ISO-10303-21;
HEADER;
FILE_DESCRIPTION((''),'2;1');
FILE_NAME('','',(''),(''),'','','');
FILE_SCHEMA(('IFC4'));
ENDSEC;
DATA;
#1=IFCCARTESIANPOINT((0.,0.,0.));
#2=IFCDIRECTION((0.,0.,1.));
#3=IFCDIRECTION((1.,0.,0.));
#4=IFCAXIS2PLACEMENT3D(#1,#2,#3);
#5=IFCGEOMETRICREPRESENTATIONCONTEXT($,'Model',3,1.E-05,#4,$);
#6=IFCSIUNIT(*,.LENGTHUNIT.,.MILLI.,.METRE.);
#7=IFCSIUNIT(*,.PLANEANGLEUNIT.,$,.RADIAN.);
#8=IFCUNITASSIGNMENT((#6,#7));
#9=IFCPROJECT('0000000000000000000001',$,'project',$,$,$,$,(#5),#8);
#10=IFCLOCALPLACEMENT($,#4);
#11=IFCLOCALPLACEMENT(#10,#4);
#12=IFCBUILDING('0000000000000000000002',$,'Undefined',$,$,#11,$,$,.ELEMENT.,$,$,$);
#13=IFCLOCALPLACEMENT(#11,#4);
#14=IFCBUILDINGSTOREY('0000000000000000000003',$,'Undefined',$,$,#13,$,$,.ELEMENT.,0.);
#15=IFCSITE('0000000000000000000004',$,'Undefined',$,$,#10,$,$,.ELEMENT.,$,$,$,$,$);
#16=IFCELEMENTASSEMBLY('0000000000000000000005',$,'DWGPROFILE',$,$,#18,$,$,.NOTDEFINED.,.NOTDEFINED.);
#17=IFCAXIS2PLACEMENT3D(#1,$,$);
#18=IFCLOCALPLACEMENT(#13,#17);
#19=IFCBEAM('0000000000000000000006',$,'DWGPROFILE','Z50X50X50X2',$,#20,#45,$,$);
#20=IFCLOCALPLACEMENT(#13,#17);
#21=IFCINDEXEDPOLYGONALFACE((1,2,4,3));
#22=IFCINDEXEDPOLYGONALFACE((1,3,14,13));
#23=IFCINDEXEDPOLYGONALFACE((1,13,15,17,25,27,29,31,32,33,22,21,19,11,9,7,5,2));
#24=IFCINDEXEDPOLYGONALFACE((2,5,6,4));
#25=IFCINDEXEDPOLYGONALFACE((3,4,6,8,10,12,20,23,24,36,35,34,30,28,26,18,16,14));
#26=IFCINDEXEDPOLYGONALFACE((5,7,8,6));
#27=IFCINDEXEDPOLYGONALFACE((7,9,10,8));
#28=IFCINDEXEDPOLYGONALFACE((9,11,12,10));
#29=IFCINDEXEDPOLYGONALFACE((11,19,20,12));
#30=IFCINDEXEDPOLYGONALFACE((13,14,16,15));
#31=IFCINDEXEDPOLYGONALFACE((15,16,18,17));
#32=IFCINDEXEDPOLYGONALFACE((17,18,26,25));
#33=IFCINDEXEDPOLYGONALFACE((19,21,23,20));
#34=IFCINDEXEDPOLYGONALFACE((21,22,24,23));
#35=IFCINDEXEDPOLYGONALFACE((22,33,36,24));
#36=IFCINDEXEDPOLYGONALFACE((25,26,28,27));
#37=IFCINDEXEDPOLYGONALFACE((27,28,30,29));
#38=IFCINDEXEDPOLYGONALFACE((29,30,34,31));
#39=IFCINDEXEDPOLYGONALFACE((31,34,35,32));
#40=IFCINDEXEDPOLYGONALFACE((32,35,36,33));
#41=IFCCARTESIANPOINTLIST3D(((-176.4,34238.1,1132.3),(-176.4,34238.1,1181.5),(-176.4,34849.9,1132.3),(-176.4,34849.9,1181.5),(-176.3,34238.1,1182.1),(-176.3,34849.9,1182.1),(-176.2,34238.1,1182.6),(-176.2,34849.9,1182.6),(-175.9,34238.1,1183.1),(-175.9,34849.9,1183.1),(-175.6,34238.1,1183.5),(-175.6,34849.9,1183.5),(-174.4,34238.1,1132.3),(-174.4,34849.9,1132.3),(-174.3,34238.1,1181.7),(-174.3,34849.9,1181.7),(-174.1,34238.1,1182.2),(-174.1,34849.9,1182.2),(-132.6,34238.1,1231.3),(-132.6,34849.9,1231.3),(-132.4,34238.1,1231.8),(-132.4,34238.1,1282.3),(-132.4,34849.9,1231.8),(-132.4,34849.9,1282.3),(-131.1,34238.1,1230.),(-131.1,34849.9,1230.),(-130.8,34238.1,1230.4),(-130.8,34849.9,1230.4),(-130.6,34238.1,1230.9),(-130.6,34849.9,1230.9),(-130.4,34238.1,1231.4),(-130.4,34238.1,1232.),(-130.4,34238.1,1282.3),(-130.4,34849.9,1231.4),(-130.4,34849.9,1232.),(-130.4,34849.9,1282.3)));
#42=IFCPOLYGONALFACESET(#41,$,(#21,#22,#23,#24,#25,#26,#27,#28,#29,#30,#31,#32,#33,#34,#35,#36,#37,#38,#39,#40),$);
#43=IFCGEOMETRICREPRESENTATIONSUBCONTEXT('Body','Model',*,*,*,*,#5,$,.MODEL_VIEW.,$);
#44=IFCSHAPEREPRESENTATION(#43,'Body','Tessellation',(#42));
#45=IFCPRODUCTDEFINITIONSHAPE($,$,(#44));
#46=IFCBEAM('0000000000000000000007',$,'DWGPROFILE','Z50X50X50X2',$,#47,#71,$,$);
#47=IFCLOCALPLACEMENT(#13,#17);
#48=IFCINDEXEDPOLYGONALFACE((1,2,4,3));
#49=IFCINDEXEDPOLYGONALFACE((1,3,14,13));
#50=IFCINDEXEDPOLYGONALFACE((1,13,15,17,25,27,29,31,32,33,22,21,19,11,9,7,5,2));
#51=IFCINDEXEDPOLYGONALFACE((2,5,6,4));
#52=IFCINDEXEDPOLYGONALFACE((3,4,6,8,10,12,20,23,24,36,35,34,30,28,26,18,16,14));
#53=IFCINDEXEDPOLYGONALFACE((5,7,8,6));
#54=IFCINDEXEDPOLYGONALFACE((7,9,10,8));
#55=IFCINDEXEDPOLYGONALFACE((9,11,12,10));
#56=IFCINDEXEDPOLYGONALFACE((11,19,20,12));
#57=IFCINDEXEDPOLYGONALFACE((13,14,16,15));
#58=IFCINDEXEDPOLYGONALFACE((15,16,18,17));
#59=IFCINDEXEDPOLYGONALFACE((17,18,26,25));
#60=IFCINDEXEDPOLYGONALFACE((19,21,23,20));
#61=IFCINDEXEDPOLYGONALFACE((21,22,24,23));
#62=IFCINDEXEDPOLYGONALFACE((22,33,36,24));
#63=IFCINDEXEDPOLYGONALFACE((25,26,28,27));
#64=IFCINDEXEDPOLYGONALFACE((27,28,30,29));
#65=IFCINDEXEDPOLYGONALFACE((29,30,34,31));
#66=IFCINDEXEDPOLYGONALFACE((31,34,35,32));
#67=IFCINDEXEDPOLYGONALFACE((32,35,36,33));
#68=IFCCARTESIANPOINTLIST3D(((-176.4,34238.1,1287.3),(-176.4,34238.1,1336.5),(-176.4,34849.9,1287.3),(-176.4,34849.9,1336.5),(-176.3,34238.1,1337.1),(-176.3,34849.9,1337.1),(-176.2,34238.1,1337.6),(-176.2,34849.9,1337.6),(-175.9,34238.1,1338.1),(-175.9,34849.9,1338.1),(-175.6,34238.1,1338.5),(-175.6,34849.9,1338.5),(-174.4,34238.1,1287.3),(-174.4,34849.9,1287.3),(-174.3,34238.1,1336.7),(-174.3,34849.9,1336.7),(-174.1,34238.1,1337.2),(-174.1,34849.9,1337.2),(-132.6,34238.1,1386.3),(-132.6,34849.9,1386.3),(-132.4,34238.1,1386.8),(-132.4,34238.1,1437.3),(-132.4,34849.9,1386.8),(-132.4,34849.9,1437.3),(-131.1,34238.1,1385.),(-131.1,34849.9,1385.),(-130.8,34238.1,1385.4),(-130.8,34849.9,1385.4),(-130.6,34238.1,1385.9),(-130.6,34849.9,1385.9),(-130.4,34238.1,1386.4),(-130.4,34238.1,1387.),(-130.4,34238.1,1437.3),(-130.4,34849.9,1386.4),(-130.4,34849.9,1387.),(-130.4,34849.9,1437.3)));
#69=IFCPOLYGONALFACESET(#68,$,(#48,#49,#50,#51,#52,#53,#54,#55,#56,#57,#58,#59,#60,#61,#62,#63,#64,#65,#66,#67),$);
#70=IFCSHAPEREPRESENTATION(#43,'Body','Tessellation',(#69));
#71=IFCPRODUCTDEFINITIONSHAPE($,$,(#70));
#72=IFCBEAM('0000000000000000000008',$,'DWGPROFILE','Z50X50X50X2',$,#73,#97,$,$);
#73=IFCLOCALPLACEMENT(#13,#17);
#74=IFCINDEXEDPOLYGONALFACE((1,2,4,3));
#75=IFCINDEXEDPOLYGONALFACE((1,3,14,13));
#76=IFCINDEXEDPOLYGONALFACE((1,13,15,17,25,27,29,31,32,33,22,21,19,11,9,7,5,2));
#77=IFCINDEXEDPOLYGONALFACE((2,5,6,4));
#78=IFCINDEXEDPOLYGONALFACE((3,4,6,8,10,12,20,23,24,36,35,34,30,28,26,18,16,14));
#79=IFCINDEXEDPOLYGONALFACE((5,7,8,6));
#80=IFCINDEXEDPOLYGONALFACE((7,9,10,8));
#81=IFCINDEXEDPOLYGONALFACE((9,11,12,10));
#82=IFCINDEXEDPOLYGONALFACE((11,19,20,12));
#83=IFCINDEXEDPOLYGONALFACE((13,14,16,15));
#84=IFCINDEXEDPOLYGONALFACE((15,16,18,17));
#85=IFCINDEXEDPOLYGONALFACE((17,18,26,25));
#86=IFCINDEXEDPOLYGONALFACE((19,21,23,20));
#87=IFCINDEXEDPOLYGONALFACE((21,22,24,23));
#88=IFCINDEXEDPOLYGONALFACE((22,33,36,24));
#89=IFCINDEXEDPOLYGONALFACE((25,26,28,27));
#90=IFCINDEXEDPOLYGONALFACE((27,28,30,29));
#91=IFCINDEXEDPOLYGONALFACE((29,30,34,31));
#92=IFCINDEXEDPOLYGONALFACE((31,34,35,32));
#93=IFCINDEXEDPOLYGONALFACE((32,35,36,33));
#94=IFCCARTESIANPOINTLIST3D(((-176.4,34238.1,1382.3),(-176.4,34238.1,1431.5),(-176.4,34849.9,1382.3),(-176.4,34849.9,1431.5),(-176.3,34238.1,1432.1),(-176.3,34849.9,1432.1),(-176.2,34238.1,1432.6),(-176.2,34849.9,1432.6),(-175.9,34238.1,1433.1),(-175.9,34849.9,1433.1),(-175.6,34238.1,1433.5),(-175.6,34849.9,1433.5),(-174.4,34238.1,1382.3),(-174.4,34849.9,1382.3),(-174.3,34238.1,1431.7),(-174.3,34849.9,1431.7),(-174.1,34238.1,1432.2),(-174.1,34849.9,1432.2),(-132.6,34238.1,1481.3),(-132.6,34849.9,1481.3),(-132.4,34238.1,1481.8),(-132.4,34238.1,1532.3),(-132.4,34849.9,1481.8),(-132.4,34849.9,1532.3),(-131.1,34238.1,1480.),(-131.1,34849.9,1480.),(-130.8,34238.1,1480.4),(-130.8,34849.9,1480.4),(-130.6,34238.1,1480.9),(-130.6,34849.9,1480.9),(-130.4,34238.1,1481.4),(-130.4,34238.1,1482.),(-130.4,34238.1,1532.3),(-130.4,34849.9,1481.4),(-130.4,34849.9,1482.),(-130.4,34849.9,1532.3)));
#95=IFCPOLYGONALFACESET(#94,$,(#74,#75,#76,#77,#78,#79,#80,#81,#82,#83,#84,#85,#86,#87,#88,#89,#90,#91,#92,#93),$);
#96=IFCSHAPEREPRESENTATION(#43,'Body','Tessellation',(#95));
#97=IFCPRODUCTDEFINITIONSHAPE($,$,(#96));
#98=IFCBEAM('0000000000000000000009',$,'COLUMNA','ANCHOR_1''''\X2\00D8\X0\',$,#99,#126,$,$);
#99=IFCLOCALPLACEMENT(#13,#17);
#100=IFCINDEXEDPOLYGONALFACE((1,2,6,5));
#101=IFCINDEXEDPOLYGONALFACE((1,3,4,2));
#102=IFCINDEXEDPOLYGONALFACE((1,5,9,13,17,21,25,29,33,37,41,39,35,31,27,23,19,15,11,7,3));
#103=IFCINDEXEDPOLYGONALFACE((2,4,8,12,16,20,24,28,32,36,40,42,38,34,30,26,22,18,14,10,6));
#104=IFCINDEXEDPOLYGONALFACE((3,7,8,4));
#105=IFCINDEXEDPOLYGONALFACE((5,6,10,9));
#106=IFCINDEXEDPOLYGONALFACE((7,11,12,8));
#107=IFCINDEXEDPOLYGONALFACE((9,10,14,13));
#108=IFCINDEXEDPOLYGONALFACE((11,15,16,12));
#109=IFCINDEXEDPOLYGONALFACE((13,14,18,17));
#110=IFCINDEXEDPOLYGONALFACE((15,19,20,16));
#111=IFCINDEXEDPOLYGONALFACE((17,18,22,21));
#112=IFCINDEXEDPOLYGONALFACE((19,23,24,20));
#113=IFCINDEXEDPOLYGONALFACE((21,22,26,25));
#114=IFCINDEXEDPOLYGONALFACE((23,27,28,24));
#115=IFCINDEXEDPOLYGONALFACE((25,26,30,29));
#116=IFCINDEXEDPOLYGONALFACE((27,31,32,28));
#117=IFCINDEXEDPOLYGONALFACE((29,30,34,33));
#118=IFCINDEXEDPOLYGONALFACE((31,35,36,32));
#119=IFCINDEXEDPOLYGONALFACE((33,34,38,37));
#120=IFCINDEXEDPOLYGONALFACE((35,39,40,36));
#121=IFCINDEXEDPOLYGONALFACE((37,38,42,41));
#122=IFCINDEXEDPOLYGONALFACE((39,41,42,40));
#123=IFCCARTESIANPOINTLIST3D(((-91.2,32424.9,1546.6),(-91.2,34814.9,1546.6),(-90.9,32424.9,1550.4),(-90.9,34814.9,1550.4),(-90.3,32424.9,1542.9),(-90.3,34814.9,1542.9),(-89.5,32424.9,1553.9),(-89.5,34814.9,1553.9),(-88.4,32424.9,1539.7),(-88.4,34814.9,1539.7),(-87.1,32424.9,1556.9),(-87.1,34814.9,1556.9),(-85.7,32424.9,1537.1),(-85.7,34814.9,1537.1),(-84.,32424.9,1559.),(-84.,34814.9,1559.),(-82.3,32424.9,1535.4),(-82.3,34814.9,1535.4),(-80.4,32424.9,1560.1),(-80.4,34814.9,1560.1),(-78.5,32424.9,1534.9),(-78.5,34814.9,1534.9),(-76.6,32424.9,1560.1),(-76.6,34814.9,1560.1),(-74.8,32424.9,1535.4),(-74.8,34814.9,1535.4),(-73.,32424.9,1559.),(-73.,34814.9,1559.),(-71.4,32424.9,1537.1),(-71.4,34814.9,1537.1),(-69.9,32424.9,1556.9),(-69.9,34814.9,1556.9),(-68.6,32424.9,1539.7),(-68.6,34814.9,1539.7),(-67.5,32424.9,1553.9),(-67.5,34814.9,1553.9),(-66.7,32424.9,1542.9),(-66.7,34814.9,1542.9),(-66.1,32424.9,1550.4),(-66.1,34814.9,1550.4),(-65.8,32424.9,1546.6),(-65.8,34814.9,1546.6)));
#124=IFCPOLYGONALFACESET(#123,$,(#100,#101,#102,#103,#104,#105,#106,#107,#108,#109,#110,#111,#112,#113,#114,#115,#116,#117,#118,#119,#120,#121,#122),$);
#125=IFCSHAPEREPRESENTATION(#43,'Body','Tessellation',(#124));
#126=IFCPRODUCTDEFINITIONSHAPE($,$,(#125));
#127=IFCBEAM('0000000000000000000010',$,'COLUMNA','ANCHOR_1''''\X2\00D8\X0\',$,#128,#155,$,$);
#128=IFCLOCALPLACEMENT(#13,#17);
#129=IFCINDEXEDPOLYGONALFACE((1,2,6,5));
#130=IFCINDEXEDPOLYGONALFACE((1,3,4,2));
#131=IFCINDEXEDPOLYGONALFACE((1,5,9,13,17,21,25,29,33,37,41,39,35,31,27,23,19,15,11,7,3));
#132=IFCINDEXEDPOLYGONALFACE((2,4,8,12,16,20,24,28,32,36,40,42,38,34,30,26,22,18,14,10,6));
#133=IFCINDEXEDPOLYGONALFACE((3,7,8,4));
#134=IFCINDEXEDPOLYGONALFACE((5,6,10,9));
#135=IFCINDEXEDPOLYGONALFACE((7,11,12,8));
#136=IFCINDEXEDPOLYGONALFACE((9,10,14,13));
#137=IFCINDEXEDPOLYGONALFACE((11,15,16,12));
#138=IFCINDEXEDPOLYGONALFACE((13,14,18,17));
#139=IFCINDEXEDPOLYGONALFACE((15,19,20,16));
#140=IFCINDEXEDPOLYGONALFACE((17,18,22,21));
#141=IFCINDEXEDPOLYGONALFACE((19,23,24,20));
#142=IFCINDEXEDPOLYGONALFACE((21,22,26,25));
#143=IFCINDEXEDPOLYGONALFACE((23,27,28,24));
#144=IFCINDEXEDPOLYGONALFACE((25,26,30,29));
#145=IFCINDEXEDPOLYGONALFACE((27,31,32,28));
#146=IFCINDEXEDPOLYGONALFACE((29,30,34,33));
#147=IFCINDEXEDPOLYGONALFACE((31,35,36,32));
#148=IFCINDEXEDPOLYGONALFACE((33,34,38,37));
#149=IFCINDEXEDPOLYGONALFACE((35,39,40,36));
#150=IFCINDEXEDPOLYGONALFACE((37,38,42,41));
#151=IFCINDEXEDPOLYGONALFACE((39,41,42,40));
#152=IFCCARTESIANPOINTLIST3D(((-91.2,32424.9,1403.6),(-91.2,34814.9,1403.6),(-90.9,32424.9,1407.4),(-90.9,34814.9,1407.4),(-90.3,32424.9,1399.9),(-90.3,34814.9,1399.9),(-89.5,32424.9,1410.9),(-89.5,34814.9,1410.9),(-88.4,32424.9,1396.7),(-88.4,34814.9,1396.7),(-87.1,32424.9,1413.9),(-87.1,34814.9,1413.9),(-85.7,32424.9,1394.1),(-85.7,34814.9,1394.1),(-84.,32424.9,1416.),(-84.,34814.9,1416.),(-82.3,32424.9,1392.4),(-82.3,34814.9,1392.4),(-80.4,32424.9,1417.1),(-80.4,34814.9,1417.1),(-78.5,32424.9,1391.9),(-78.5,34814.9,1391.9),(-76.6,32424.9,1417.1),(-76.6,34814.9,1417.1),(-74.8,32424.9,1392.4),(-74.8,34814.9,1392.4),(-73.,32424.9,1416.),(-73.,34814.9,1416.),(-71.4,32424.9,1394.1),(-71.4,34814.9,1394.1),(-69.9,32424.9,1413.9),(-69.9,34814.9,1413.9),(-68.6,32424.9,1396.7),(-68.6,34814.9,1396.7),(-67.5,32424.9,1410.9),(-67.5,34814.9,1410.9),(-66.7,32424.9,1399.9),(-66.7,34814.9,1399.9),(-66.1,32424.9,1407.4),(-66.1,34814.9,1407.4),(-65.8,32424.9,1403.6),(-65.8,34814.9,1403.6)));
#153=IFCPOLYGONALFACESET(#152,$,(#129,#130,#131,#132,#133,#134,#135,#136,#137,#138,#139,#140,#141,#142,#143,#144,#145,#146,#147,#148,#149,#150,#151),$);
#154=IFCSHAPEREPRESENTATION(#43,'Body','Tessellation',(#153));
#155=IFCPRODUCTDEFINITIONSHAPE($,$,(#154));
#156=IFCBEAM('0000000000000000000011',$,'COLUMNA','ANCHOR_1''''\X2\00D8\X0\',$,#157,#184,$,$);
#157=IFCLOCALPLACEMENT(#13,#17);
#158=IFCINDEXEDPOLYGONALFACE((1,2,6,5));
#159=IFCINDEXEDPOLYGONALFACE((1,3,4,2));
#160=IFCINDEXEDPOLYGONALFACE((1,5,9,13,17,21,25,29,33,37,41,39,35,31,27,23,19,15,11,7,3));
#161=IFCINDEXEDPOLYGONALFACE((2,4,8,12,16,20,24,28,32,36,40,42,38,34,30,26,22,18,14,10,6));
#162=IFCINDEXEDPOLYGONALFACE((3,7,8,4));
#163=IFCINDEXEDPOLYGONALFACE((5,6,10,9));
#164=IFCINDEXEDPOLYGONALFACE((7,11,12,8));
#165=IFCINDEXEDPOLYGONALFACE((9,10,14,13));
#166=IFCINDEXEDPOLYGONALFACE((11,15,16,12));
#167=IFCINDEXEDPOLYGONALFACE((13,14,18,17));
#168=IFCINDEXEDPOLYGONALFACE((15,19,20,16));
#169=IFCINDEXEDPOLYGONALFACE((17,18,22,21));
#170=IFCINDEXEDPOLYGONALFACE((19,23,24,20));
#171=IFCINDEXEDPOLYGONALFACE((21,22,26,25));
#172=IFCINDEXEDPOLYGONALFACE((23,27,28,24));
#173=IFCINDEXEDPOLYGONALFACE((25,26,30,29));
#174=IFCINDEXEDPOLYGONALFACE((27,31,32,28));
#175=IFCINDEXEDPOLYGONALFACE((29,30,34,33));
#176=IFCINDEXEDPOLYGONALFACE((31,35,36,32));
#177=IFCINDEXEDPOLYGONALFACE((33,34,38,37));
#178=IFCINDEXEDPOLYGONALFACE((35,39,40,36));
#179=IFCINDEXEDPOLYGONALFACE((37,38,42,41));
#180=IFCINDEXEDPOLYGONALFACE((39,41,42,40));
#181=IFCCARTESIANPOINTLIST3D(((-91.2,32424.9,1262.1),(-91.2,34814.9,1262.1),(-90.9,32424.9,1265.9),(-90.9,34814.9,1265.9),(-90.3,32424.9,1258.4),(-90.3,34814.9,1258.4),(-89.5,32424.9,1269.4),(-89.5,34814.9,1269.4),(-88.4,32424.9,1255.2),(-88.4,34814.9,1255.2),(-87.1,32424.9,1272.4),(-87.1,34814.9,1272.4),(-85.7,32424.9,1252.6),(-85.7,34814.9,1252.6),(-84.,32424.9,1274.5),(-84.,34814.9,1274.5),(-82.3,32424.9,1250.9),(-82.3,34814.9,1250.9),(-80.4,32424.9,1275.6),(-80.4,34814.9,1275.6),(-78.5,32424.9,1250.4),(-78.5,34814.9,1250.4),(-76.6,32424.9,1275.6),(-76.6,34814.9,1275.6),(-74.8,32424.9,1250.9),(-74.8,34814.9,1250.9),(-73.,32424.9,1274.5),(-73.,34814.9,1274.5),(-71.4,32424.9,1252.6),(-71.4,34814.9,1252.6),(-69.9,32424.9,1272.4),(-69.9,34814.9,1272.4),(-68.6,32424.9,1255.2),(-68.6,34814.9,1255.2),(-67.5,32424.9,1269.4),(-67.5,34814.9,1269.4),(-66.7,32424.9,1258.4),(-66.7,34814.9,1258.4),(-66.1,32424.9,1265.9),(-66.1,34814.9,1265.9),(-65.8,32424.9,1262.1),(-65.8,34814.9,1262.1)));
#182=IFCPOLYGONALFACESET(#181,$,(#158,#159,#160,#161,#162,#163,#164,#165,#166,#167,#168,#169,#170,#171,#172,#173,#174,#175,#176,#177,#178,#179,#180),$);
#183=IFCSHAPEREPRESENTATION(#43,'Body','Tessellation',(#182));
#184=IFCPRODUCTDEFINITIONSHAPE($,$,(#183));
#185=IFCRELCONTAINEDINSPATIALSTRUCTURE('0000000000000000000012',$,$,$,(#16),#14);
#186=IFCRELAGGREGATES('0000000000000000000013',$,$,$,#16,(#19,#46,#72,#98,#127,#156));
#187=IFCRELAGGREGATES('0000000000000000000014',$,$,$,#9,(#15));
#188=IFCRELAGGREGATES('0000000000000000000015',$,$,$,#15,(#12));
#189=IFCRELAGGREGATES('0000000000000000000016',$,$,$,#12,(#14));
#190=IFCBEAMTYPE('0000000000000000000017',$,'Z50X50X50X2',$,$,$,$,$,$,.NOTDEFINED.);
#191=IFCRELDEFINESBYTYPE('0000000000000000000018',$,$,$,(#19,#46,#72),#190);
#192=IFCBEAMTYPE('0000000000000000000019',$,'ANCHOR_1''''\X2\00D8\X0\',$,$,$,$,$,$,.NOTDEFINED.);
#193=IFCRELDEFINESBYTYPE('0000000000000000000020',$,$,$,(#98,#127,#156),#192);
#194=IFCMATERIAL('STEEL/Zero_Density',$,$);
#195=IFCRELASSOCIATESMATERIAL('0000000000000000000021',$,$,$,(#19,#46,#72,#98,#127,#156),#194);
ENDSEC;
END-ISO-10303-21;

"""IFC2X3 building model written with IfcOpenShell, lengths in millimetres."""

from ifc_helpers import new_model, si_unit, frame, origin_with_axes, origin_2d_with_axis, place, context, subcontext, project, spatial, polyline, circle, outline, extrude, material, type_object, element, aggregate, save


model = new_model("IFC2X3")

# Units and contexts
model_context = context("Model", 3, precision=1e-05, world=origin_with_axes())
body_context = subcontext(model_context, "Body", "Model", "MODEL_VIEW")
ifc_project = project(units=[si_unit("LENGTHUNIT", "METRE", prefix="MILLI"), si_unit("PLANEANGLEUNIT", "RADIAN")], contexts=[model_context])

# Site, building, storey
site_placement = place(None, origin_with_axes())
site = spatial("IfcSite", under=ifc_project, at=site_placement, Name="Undefined", CompositionType="ELEMENT")
building_placement = place(site_placement, origin_with_axes())
building = spatial("IfcBuilding", under=site, at=building_placement, Name="Undefined", CompositionType="ELEMENT")
storey_placement = place(building_placement, origin_with_axes())
storey = spatial("IfcBuildingStorey", under=building, at=storey_placement, Name="Undefined", CompositionType="ELEMENT", Elevation=0.0)

# Element assembly, beams
assembly_1_placement = place(storey_placement, origin_with_axes())
assembly_1 = element("IfcElementAssembly", 1, at=assembly_1_placement, inside=storey, Name="DWGPROFILE", AssemblyPlace="NOTDEFINED", PredefinedType="NOTDEFINED")
ifc_material_1 = material(Name="STEEL/Zero_Density")
beam_type_1 = type_object("IfcBeamType", Name="Z50X50X50X2", PredefinedType="NOTDEFINED")
beam_1_placement = place(assembly_1_placement, frame((-153.4, 34849.9, 1207.3), z_axis=(0.0, 0.0, 1.0), x_axis=(0.0, -1.0, 0.0)))
beam_1 = element("IfcBeam", 2, at=beam_1_placement, type_object=beam_type_1, material=ifc_material_1, Name="DWGPROFILE", Description="Z50X50X50X2", context=body_context, shape_type="SweptSolid", body=[
    extrude(outline(polyline([(-22.9, 24.1), (-23.0, 24.7), (-23.0, 75.0), (-21.0, 75.0), (-21.0, 24.5), (-20.7, 24.0), (22.2, -23.8), (22.6, -24.2), (22.8, -24.7), (22.9, -25.2), (23.0, -25.8), (23.0, -75.0), (21.0, -75.0), (21.0, -25.6), (20.7, -25.1), (-22.2, 22.6), (-22.6, 23.1), (-22.8, 23.6), (-22.9, 24.1)])), frame((611.8, 0.0, 0.0), z_axis=(-1.0, 0.0, 0.0), x_axis=(0.0, -1.0, 0.0)), (0.0, 0.0, 1.0), 611.8),
])
beam_2_placement = place(assembly_1_placement, frame((-153.4, 34849.9, 1362.3), z_axis=(0.0, 0.0, 1.0), x_axis=(0.0, -1.0, 0.0)))
beam_2 = element("IfcBeam", 3, at=beam_2_placement, type_object=beam_type_1, material=ifc_material_1, Name="DWGPROFILE", Description="Z50X50X50X2", context=body_context, shape_type="SweptSolid", body=[
    extrude(outline(polyline([(-22.9, 24.1), (-23.0, 24.7), (-23.0, 75.0), (-21.0, 75.0), (-21.0, 24.5), (-20.7, 24.0), (22.2, -23.8), (22.6, -24.2), (22.8, -24.7), (22.9, -25.2), (23.0, -25.8), (23.0, -75.0), (21.0, -75.0), (21.0, -25.6), (20.7, -25.1), (-22.2, 22.6), (-22.6, 23.1), (-22.8, 23.6), (-22.9, 24.1)])), frame((611.8, 0.0, 0.0), z_axis=(-1.0, 0.0, 0.0), x_axis=(0.0, -1.0, 0.0)), (0.0, 0.0, 1.0), 611.8),
])
beam_3_placement = place(assembly_1_placement, frame((-153.4, 34849.9, 1457.3), z_axis=(0.0, 0.0, 1.0), x_axis=(0.0, -1.0, 0.0)))
beam_3 = element("IfcBeam", 4, at=beam_3_placement, type_object=beam_type_1, material=ifc_material_1, Name="DWGPROFILE", Description="Z50X50X50X2", context=body_context, shape_type="SweptSolid", body=[
    extrude(outline(polyline([(-22.9, 24.1), (-23.0, 24.7), (-23.0, 75.0), (-21.0, 75.0), (-21.0, 24.5), (-20.7, 24.0), (22.2, -23.8), (22.6, -24.2), (22.8, -24.7), (22.9, -25.2), (23.0, -25.8), (23.0, -75.0), (21.0, -75.0), (21.0, -25.6), (20.7, -25.1), (-22.2, 22.6), (-22.6, 23.1), (-22.8, 23.6), (-22.9, 24.1)])), frame((611.8, 0.0, 0.0), z_axis=(-1.0, 0.0, 0.0), x_axis=(0.0, -1.0, 0.0)), (0.0, 0.0, 1.0), 611.8),
])
beam_type_2 = type_object("IfcBeamType", Name="ANCHOR_1''Ø", PredefinedType="NOTDEFINED")
beam_4_placement = place(assembly_1_placement, frame((-78.5, 34814.9, 1547.6), z_axis=(-1.0, 0.0, 0.0), x_axis=(0.0, -1.0, 0.0)))
beam_4 = element("IfcBeam", 5, at=beam_4_placement, type_object=beam_type_2, material=ifc_material_1, Name="COLUMNA", Description="ANCHOR_1''Ø", context=body_context, shape_type="SweptSolid", body=[
    extrude(circle(Radius=12.7, at=origin_2d_with_axis()), frame((2390.0, 0.0, 0.0), z_axis=(-1.0, 0.0, 0.0), x_axis=(0.0, -1.0, 0.0)), (0.0, 0.0, 1.0), 2390.0),
])
beam_5_placement = place(assembly_1_placement, frame((-78.5, 34814.9, 1404.6), z_axis=(-1.0, 0.0, 0.0), x_axis=(0.0, -1.0, 0.0)))
beam_5 = element("IfcBeam", 6, at=beam_5_placement, type_object=beam_type_2, material=ifc_material_1, Name="COLUMNA", Description="ANCHOR_1''Ø", context=body_context, shape_type="SweptSolid", body=[
    extrude(circle(Radius=12.7, at=origin_2d_with_axis()), frame((2390.0, 0.0, 0.0), z_axis=(-1.0, 0.0, 0.0), x_axis=(0.0, -1.0, 0.0)), (0.0, 0.0, 1.0), 2390.0),
])
beam_6_placement = place(assembly_1_placement, frame((-78.5, 34814.9, 1263.1), z_axis=(-1.0, 0.0, 0.0), x_axis=(0.0, -1.0, 0.0)))
beam_6 = element("IfcBeam", 7, at=beam_6_placement, type_object=beam_type_2, material=ifc_material_1, Name="COLUMNA", Description="ANCHOR_1''Ø", context=body_context, shape_type="SweptSolid", body=[
    extrude(circle(Radius=12.7, at=origin_2d_with_axis()), frame((2390.0, 0.0, 0.0), z_axis=(-1.0, 0.0, 0.0), x_axis=(0.0, -1.0, 0.0)), (0.0, 0.0, 1.0), 2390.0),
])

aggregate(assembly_1, [beam_1, beam_2, beam_3, beam_4, beam_5, beam_6])

save(model, "model.ifc")
